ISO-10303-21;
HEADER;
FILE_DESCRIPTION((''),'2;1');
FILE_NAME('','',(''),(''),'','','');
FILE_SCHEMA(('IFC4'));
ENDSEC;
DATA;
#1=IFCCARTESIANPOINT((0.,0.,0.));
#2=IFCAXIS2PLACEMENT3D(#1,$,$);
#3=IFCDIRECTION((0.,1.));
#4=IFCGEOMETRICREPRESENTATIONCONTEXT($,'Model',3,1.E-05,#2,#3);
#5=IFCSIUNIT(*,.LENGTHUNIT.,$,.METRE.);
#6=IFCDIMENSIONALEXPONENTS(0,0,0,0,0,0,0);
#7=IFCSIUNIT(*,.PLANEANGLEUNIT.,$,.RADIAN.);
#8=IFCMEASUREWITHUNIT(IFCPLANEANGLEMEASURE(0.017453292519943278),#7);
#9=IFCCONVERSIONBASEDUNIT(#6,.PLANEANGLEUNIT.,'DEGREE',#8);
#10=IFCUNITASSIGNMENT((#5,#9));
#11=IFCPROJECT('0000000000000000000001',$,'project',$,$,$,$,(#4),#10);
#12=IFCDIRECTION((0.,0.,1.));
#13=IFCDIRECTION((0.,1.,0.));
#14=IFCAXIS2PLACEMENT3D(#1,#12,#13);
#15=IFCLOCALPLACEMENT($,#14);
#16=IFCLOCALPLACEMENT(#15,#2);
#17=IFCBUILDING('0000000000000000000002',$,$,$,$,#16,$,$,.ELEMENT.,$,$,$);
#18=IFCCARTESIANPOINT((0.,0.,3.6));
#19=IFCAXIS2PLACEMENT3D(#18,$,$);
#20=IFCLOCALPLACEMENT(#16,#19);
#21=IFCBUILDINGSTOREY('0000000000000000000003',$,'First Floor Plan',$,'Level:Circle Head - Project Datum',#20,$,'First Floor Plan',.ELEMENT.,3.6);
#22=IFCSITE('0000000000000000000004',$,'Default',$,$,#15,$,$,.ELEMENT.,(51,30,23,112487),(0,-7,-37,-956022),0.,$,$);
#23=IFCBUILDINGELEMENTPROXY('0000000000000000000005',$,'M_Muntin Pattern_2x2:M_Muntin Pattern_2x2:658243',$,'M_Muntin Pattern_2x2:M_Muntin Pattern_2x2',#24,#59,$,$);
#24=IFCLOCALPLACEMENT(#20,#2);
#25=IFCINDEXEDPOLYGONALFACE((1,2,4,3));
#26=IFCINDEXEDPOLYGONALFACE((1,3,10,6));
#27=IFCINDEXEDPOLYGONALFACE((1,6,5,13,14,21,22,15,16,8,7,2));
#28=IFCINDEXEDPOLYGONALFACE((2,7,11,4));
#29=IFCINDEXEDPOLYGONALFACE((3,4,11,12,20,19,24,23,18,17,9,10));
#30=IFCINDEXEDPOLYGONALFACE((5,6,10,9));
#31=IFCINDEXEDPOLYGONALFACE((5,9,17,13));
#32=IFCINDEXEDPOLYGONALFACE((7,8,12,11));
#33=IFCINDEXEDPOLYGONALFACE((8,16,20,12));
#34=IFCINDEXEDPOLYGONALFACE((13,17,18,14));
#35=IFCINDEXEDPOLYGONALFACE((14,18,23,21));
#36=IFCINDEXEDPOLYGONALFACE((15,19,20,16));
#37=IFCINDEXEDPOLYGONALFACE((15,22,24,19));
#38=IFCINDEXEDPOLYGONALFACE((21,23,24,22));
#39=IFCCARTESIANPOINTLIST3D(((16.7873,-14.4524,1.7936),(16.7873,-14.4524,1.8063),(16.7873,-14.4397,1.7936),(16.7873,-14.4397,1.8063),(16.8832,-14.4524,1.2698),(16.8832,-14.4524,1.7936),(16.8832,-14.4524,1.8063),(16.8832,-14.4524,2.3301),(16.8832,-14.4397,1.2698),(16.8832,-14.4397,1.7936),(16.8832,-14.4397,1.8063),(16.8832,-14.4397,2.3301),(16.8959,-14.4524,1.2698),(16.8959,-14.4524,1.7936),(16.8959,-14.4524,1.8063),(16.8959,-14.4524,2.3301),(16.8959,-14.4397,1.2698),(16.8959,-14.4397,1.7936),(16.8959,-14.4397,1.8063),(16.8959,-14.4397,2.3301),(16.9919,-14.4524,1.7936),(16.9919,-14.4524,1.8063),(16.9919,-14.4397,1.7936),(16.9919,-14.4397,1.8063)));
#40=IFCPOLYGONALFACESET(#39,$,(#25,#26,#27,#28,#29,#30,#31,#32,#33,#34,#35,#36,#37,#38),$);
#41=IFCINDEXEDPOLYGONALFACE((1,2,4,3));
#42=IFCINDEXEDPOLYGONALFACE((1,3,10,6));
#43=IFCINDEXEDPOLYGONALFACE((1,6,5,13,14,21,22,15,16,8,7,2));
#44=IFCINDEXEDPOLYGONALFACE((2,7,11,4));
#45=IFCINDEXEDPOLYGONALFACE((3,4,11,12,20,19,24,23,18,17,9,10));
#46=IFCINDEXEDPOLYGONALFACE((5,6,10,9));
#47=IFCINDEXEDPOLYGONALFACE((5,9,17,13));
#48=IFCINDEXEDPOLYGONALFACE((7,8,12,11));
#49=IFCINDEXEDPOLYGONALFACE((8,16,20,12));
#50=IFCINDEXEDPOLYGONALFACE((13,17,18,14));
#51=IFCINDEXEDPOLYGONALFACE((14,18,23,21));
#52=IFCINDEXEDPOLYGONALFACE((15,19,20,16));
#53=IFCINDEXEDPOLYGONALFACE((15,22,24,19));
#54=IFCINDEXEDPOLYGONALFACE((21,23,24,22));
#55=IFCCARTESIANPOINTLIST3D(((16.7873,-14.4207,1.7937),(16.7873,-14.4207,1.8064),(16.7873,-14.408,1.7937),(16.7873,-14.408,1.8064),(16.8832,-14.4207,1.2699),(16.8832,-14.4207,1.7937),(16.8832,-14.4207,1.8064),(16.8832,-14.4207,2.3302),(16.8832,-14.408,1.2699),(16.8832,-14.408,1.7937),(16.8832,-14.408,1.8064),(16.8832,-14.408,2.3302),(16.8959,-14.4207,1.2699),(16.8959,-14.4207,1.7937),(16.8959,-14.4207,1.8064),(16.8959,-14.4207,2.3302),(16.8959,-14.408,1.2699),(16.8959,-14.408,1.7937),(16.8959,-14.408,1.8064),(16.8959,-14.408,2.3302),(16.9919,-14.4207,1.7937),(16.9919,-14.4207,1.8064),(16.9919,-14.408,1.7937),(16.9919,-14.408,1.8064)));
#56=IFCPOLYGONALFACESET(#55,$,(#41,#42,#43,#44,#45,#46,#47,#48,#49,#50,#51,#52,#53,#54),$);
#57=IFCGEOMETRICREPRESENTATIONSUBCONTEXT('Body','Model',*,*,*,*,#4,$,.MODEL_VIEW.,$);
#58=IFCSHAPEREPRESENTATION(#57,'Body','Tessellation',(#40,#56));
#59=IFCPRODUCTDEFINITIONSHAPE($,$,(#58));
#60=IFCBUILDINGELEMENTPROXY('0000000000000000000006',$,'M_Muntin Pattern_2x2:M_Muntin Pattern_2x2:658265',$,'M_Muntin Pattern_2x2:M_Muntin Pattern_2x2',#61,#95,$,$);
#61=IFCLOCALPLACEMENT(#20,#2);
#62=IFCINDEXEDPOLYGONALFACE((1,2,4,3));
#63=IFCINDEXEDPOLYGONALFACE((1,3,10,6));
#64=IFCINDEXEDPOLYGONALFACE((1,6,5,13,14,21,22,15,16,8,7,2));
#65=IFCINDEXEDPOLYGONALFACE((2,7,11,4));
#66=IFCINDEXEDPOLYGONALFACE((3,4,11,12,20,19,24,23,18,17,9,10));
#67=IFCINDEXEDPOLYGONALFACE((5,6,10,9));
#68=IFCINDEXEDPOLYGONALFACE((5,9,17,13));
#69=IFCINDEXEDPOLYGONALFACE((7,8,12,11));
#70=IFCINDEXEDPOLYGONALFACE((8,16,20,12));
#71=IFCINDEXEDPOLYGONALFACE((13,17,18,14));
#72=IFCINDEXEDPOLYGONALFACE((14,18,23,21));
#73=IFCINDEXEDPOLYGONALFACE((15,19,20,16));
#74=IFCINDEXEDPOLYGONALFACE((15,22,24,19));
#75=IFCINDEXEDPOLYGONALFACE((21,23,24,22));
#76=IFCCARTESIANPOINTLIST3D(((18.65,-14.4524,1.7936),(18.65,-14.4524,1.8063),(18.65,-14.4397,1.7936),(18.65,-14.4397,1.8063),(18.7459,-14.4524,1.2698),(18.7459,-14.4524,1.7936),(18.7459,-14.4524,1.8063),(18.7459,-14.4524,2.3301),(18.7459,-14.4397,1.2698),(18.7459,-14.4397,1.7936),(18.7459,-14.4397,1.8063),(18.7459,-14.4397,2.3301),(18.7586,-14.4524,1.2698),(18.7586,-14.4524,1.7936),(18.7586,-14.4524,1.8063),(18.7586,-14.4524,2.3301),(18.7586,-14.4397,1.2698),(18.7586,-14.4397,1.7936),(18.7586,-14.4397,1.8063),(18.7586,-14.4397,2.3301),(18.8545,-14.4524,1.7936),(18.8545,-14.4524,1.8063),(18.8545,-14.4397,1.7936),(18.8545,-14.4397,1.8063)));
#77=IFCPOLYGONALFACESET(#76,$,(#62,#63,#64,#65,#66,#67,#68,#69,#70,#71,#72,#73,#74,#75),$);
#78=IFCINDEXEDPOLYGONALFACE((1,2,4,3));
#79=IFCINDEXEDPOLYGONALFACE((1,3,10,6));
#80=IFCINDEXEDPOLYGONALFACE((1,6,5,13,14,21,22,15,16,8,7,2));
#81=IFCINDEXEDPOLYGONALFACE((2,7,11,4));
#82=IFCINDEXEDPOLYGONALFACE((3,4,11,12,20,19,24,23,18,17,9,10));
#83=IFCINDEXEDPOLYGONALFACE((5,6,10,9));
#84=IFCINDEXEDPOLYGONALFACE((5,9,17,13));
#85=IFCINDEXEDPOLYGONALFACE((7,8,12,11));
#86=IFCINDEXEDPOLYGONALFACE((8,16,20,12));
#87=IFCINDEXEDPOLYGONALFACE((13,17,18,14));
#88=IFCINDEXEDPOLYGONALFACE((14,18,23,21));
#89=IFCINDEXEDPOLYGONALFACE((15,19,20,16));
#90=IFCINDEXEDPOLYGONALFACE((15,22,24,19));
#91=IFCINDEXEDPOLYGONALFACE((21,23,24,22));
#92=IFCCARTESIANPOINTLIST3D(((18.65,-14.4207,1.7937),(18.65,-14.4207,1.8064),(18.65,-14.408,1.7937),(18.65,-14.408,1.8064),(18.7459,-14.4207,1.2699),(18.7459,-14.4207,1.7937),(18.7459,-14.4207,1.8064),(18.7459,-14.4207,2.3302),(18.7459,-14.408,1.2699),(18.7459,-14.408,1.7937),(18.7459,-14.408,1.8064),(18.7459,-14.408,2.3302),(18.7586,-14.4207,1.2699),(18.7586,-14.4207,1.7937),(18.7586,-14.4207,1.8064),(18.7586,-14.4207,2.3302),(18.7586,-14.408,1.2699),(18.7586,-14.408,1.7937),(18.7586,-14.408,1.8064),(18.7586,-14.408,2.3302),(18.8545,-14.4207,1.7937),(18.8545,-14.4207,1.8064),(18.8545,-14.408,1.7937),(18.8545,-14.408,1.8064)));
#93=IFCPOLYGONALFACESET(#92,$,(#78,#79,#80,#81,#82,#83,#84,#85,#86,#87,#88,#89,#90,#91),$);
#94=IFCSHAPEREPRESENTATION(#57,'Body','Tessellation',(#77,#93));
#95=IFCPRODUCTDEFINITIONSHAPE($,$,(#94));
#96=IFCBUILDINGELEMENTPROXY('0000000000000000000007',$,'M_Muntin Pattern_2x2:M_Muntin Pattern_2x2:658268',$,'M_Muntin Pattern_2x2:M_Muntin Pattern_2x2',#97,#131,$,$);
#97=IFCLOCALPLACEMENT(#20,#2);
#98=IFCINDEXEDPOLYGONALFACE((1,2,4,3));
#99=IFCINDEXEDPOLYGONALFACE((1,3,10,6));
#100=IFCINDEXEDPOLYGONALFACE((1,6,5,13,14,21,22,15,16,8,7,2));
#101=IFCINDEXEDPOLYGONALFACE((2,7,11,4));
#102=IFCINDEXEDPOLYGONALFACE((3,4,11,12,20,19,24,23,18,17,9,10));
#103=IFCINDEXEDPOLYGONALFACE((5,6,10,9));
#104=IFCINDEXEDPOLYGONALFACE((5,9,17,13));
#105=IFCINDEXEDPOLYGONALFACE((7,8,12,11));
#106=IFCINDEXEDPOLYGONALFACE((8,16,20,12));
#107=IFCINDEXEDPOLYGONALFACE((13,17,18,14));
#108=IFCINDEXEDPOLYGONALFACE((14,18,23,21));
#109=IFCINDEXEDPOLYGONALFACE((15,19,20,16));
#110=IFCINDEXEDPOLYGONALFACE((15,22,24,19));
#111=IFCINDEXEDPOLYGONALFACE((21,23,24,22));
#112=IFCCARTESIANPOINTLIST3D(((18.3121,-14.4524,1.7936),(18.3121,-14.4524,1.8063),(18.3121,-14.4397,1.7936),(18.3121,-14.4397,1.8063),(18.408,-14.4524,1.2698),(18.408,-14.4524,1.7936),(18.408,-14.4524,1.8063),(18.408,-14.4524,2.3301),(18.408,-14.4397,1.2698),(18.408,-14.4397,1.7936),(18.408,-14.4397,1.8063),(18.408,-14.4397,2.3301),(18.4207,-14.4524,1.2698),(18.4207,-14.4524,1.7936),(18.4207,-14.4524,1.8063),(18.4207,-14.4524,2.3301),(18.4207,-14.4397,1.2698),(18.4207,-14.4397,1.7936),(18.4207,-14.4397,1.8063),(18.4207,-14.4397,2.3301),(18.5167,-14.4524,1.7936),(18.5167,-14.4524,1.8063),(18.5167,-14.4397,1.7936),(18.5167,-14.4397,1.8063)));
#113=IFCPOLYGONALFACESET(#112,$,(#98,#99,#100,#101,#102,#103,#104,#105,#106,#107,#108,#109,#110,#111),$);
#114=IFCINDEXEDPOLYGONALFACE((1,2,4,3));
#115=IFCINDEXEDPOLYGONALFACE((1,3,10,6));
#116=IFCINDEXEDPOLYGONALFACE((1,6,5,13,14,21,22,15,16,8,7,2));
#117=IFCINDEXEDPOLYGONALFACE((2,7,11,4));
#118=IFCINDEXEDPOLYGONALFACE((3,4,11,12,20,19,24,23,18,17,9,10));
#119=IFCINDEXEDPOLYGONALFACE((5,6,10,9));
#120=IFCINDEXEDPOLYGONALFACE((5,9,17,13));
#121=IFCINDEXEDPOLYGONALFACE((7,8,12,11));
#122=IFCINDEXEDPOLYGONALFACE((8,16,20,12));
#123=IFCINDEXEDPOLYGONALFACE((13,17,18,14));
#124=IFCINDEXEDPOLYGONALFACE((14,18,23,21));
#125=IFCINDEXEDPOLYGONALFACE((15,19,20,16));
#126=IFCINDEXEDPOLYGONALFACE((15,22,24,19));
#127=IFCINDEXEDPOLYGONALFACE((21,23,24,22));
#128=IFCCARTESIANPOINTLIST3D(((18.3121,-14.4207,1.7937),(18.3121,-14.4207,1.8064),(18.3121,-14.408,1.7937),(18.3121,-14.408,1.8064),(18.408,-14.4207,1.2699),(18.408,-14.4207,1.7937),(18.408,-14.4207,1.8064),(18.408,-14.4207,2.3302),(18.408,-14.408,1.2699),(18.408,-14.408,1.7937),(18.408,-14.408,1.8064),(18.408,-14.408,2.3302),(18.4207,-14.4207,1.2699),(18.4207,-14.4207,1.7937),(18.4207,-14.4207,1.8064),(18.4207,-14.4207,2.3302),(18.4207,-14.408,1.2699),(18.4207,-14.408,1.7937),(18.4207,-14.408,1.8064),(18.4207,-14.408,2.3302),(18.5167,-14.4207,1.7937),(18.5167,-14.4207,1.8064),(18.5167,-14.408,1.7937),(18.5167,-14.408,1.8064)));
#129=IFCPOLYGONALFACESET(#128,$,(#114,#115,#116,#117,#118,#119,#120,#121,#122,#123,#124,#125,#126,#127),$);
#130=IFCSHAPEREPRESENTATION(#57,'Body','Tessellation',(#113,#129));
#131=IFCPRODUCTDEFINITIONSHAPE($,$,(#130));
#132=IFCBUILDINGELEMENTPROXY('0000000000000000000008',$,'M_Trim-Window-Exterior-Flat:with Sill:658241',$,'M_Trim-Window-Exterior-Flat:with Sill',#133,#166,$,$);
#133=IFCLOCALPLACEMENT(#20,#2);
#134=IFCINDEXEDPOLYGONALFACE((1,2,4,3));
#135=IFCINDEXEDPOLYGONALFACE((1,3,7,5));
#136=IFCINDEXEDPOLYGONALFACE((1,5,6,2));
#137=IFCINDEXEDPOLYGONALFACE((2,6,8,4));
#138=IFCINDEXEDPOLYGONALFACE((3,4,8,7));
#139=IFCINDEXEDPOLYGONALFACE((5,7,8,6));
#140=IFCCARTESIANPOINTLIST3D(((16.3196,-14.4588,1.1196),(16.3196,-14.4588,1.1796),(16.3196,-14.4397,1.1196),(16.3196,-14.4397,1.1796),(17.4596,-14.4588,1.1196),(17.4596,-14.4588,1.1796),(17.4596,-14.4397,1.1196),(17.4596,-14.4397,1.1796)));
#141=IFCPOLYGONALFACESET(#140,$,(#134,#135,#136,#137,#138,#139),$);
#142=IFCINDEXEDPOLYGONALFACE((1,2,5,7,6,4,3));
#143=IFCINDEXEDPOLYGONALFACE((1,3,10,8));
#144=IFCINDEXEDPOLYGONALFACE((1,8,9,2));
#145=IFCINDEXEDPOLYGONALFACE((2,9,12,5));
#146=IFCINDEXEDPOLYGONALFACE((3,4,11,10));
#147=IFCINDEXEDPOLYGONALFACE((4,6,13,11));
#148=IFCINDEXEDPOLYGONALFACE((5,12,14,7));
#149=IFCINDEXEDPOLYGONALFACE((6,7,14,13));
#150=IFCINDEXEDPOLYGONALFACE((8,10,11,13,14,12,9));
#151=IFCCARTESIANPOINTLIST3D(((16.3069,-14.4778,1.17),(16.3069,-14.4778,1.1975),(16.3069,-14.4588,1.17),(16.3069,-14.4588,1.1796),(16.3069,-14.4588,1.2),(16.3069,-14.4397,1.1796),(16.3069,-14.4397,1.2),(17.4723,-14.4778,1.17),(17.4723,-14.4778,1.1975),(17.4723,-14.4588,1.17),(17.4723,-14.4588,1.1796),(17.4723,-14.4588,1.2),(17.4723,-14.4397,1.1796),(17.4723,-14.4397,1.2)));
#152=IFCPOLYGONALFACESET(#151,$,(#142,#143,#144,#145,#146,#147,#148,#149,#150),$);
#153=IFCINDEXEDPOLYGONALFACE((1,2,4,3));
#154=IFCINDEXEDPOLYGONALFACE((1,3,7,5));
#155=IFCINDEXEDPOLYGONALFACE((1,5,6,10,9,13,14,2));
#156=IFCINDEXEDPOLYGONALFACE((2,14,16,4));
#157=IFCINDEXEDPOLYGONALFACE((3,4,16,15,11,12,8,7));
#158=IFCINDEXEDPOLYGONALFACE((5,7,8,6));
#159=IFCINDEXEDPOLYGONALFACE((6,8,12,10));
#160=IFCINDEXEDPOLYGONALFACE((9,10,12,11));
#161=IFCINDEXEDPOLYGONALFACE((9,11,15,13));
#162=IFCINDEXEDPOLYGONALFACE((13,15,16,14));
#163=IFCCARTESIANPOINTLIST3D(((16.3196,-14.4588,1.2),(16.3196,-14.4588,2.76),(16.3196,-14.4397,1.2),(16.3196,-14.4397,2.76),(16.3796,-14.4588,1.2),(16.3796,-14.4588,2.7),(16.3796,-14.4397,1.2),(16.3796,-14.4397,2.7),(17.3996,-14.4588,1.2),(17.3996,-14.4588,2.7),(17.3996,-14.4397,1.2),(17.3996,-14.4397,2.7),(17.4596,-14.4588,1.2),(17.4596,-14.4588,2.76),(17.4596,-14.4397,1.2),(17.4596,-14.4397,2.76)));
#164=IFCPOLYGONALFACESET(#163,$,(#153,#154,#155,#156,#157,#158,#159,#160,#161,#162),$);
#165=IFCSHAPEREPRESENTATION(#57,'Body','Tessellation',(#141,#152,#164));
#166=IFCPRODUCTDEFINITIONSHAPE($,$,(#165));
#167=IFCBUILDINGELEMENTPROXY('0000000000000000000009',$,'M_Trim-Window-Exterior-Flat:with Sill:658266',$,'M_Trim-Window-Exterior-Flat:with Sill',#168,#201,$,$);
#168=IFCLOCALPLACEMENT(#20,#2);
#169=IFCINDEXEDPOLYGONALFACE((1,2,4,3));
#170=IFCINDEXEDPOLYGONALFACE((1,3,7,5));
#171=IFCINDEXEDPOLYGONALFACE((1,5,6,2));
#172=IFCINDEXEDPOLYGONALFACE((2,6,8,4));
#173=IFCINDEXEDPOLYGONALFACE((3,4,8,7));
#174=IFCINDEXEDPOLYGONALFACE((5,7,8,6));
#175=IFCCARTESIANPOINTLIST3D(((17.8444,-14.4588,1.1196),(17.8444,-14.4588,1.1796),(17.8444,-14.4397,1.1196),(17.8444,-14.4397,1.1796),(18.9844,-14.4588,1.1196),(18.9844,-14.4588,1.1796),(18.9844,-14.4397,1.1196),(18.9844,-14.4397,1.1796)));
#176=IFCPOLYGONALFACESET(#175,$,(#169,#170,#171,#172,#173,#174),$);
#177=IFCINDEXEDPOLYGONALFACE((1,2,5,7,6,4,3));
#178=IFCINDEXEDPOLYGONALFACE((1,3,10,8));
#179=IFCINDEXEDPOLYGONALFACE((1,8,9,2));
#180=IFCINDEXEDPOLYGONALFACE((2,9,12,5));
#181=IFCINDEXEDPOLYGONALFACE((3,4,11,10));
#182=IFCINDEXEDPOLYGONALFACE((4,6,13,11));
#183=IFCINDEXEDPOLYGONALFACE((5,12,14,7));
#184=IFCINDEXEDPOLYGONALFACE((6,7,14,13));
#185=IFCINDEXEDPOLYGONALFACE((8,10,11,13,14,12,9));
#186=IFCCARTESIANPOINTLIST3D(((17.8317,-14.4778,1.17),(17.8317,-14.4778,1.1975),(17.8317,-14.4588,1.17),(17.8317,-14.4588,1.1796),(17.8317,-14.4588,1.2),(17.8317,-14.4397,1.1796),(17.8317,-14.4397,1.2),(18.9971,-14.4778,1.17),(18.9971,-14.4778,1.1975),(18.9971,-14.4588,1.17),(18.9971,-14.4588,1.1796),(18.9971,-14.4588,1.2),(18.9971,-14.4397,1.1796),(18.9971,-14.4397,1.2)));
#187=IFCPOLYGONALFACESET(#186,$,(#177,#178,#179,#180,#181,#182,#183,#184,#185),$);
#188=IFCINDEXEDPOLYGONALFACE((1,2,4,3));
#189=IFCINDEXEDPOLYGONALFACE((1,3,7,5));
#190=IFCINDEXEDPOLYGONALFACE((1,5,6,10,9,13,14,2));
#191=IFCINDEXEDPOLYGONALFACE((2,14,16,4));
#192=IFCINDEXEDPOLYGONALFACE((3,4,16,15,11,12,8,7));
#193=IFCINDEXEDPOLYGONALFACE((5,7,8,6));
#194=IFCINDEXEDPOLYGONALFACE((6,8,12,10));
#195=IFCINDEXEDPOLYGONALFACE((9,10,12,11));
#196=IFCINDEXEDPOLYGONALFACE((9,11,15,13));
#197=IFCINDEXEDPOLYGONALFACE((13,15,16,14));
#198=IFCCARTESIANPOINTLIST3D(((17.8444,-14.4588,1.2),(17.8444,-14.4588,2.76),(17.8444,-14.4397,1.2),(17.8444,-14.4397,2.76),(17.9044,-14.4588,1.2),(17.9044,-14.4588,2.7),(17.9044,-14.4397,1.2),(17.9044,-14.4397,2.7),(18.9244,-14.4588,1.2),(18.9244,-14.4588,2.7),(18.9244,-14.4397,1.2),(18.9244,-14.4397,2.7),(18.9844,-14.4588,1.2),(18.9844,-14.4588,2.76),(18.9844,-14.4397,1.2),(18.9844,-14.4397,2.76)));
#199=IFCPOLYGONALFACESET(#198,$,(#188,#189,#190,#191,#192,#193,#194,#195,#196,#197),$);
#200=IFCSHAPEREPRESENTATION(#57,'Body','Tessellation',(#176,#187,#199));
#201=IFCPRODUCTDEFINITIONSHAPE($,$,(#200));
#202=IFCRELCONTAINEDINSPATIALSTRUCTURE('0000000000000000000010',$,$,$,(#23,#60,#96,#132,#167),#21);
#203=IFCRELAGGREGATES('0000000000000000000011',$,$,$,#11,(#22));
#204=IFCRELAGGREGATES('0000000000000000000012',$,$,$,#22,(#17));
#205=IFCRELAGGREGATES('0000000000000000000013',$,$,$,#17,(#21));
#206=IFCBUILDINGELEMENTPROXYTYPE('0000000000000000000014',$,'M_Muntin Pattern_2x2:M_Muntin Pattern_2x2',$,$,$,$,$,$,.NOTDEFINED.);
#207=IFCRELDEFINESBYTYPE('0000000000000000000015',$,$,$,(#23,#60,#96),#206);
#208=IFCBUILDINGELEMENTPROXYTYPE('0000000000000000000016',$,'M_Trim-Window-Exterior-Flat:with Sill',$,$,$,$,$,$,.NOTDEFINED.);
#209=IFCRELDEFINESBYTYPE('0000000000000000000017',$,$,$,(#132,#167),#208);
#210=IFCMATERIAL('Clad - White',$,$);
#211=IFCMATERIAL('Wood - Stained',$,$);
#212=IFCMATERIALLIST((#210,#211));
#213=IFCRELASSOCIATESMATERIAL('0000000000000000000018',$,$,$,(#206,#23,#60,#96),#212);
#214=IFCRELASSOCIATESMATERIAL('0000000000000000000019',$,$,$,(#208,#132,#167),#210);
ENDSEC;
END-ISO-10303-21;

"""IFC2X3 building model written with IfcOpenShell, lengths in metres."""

from ifc_helpers import new_model, entity, si_unit, converted_unit, direction, frame, frame_2d, origin, place, context, subcontext, project, spatial, polyline, rectangle, outline, extrude, source, transform, mapped, material, material_list, type_object, type_shapes, element, save


model = new_model("IFC2X3")

# Units and contexts
model_context = context("Model", 3, precision=1e-05, world=origin(), true_north=direction((0.0, 1.0)))
body_context = subcontext(model_context, "Body", "Model", "MODEL_VIEW")
ifc_project = project(units=[si_unit("LENGTHUNIT", "METRE"), converted_unit("PLANEANGLEUNIT", "DEGREE", entity("IfcPlaneAngleMeasure", 0.017453292519943278), si_unit("PLANEANGLEUNIT", "RADIAN"), dimensions=[0, 0, 0, 0, 0, 0, 0])], contexts=[model_context])

# Site, building, storey
site_placement = place(None, frame((0.0, 0.0, 0.0), z_axis=(0.0, 0.0, 1.0), x_axis=(0.0, 1.0, 0.0)))
site = spatial("IfcSite", under=ifc_project, at=site_placement, Name="Default", CompositionType="ELEMENT", RefLatitude=(51, 30, 23, 112487), RefLongitude=(0, -7, -37, -956022), RefElevation=0.0)
building_placement = place(site_placement, origin())
building = spatial("IfcBuilding", under=site, at=building_placement, CompositionType="ELEMENT")
storey_placement = place(building_placement, frame((0.0, 0.0, 3.6)))
storey = spatial("IfcBuildingStorey", under=building, at=storey_placement, Name="First Floor Plan", ObjectType="Level:Circle Head - Project Datum", LongName="First Floor Plan", CompositionType="ELEMENT", Elevation=3.6)

# Building element proxies
ifc_material_1 = material(Name="Clad - White")
ifc_material_2 = material(Name="Wood - Stained")
ifc_material_list = material_list([ifc_material_1, ifc_material_2])
building_element_proxy_type_1 = type_object("IfcBuildingElementProxyType", Name="M_Muntin Pattern_2x2:M_Muntin Pattern_2x2", PredefinedType="NOTDEFINED", material=ifc_material_list)
shared_shape_1 = source(origin(), body_context, "Body", "SweptSolid", [
    extrude(outline(polyline([(0.0064, -0.0064), (0.5301, -0.0064), (0.5301, 0.0063), (0.0064, 0.0063), (0.0064, 0.1023), (-0.0063, 0.1023), (-0.0063, 0.0063), (-0.5302, 0.0063), (-0.5302, -0.0064), (-0.0063, -0.0064), (-0.0063, -0.1023), (0.0064, -0.1023), (0.0064, -0.0064)])), frame((0.0, 0.0095, 0.5301), z_axis=(0.0, 1.0, 0.0), x_axis=(0.0, 0.0, 1.0)), (0.0, 0.0, 1.0), 0.0127),
    extrude(outline(polyline([(0.0064, -0.0064), (0.5302, -0.0064), (0.5302, 0.0063), (0.0064, 0.0063), (0.0064, 0.1023), (-0.0063, 0.1023), (-0.0063, 0.0063), (-0.5302, 0.0063), (-0.5302, -0.0064), (-0.0063, -0.0064), (-0.0063, -0.1023), (0.0064, -0.1023), (0.0064, -0.0064)])), frame((0.0, -0.0222, 0.5302), z_axis=(0.0, 1.0, 0.0), x_axis=(0.0, 0.0, 1.0)), (0.0, 0.0, 1.0), 0.0127),
])
type_shapes(building_element_proxy_type_1, [shared_shape_1])
for number, where, z_axis, x_axis, name in (
    (1, (16.8896, -14.4302, 1.2699), (0.0, 0.0, 1.0), (-1.0, 0.0, 0.0), "M_Muntin Pattern_2x2:M_Muntin Pattern_2x2:658243"),
    (2, (18.7523, -14.4302, 1.2699), (0.0, 0.0, 1.0), (-1.0, 0.0, 0.0), "M_Muntin Pattern_2x2:M_Muntin Pattern_2x2:658265"),
    (3, (18.4144, -14.4302, 1.2699), (0.0, 0.0, 1.0), (-1.0, 0.0, 0.0), "M_Muntin Pattern_2x2:M_Muntin Pattern_2x2:658268"),
):
    element("IfcBuildingElementProxy", number, at=place(storey_placement, frame(where, z_axis=z_axis, x_axis=x_axis)), inside=storey, type_object=building_element_proxy_type_1, material=ifc_material_list, Name=name, ObjectType="M_Muntin Pattern_2x2:M_Muntin Pattern_2x2", context=body_context, shape_type="MappedRepresentation", body=[
        mapped(shared_shape_1, transform((0.0, 0.0, 0.0), scale=1.0)),
    ])
building_element_proxy_type_2 = type_object("IfcBuildingElementProxyType", Name="M_Trim-Window-Exterior-Flat:with Sill", PredefinedType="NOTDEFINED", material=ifc_material_1)
shared_shape_2 = source(origin(), body_context, "Body", "SweptSolid", [
    extrude(rectangle(XDim=0.06, YDim=1.14, at=frame_2d((0.0, 0.0), x_axis=(1.0, 0.0))), frame((0.0, 1.5504, 0.0), z_axis=(0.0, 0.0, 1.0), x_axis=(0.0, 1.0, 0.0)), (0.0, 0.0, 1.0), 0.019),
    extrude(outline(polyline([(-0.0152, -0.019), (0.0123, -0.019), (0.0148, 0.0), (0.0148, 0.019), (-0.0057, 0.019), (-0.0057, 0.0), (-0.0152, 0.0), (-0.0152, -0.019)])), frame((-0.5827, 1.5148, 0.019), z_axis=(1.0, 0.0, 0.0), x_axis=(0.0, -1.0, 0.0)), (0.0, 0.0, 1.0), 1.1654),
    extrude(outline(polyline([(-0.57, -0.795), (0.57, -0.795), (0.57, 0.765), (0.51, 0.765), (0.51, -0.735), (-0.51, -0.735), (-0.51, 0.765), (-0.57, 0.765), (-0.57, -0.795)])), frame((0.0, 0.735, 0.0)), (0.0, 0.0, 1.0), 0.019),
])
type_shapes(building_element_proxy_type_2, [shared_shape_2])
for number, where, z_axis, x_axis, name in (
    (4, (16.8896, -14.4397, 2.7), (0.0, -1.0, 0.0), (-1.0, 0.0, 0.0), "M_Trim-Window-Exterior-Flat:with Sill:658241"),
    (5, (18.4144, -14.4397, 2.7), (0.0, -1.0, 0.0), (-1.0, 0.0, 0.0), "M_Trim-Window-Exterior-Flat:with Sill:658266"),
):
    element("IfcBuildingElementProxy", number, at=place(storey_placement, frame(where, z_axis=z_axis, x_axis=x_axis)), inside=storey, type_object=building_element_proxy_type_2, material=ifc_material_1, Name=name, ObjectType="M_Trim-Window-Exterior-Flat:with Sill", context=body_context, shape_type="MappedRepresentation", body=[
        mapped(shared_shape_2, transform((0.0, 0.0, 0.0), scale=1.0)),
    ])

save(model, "model.ifc")
